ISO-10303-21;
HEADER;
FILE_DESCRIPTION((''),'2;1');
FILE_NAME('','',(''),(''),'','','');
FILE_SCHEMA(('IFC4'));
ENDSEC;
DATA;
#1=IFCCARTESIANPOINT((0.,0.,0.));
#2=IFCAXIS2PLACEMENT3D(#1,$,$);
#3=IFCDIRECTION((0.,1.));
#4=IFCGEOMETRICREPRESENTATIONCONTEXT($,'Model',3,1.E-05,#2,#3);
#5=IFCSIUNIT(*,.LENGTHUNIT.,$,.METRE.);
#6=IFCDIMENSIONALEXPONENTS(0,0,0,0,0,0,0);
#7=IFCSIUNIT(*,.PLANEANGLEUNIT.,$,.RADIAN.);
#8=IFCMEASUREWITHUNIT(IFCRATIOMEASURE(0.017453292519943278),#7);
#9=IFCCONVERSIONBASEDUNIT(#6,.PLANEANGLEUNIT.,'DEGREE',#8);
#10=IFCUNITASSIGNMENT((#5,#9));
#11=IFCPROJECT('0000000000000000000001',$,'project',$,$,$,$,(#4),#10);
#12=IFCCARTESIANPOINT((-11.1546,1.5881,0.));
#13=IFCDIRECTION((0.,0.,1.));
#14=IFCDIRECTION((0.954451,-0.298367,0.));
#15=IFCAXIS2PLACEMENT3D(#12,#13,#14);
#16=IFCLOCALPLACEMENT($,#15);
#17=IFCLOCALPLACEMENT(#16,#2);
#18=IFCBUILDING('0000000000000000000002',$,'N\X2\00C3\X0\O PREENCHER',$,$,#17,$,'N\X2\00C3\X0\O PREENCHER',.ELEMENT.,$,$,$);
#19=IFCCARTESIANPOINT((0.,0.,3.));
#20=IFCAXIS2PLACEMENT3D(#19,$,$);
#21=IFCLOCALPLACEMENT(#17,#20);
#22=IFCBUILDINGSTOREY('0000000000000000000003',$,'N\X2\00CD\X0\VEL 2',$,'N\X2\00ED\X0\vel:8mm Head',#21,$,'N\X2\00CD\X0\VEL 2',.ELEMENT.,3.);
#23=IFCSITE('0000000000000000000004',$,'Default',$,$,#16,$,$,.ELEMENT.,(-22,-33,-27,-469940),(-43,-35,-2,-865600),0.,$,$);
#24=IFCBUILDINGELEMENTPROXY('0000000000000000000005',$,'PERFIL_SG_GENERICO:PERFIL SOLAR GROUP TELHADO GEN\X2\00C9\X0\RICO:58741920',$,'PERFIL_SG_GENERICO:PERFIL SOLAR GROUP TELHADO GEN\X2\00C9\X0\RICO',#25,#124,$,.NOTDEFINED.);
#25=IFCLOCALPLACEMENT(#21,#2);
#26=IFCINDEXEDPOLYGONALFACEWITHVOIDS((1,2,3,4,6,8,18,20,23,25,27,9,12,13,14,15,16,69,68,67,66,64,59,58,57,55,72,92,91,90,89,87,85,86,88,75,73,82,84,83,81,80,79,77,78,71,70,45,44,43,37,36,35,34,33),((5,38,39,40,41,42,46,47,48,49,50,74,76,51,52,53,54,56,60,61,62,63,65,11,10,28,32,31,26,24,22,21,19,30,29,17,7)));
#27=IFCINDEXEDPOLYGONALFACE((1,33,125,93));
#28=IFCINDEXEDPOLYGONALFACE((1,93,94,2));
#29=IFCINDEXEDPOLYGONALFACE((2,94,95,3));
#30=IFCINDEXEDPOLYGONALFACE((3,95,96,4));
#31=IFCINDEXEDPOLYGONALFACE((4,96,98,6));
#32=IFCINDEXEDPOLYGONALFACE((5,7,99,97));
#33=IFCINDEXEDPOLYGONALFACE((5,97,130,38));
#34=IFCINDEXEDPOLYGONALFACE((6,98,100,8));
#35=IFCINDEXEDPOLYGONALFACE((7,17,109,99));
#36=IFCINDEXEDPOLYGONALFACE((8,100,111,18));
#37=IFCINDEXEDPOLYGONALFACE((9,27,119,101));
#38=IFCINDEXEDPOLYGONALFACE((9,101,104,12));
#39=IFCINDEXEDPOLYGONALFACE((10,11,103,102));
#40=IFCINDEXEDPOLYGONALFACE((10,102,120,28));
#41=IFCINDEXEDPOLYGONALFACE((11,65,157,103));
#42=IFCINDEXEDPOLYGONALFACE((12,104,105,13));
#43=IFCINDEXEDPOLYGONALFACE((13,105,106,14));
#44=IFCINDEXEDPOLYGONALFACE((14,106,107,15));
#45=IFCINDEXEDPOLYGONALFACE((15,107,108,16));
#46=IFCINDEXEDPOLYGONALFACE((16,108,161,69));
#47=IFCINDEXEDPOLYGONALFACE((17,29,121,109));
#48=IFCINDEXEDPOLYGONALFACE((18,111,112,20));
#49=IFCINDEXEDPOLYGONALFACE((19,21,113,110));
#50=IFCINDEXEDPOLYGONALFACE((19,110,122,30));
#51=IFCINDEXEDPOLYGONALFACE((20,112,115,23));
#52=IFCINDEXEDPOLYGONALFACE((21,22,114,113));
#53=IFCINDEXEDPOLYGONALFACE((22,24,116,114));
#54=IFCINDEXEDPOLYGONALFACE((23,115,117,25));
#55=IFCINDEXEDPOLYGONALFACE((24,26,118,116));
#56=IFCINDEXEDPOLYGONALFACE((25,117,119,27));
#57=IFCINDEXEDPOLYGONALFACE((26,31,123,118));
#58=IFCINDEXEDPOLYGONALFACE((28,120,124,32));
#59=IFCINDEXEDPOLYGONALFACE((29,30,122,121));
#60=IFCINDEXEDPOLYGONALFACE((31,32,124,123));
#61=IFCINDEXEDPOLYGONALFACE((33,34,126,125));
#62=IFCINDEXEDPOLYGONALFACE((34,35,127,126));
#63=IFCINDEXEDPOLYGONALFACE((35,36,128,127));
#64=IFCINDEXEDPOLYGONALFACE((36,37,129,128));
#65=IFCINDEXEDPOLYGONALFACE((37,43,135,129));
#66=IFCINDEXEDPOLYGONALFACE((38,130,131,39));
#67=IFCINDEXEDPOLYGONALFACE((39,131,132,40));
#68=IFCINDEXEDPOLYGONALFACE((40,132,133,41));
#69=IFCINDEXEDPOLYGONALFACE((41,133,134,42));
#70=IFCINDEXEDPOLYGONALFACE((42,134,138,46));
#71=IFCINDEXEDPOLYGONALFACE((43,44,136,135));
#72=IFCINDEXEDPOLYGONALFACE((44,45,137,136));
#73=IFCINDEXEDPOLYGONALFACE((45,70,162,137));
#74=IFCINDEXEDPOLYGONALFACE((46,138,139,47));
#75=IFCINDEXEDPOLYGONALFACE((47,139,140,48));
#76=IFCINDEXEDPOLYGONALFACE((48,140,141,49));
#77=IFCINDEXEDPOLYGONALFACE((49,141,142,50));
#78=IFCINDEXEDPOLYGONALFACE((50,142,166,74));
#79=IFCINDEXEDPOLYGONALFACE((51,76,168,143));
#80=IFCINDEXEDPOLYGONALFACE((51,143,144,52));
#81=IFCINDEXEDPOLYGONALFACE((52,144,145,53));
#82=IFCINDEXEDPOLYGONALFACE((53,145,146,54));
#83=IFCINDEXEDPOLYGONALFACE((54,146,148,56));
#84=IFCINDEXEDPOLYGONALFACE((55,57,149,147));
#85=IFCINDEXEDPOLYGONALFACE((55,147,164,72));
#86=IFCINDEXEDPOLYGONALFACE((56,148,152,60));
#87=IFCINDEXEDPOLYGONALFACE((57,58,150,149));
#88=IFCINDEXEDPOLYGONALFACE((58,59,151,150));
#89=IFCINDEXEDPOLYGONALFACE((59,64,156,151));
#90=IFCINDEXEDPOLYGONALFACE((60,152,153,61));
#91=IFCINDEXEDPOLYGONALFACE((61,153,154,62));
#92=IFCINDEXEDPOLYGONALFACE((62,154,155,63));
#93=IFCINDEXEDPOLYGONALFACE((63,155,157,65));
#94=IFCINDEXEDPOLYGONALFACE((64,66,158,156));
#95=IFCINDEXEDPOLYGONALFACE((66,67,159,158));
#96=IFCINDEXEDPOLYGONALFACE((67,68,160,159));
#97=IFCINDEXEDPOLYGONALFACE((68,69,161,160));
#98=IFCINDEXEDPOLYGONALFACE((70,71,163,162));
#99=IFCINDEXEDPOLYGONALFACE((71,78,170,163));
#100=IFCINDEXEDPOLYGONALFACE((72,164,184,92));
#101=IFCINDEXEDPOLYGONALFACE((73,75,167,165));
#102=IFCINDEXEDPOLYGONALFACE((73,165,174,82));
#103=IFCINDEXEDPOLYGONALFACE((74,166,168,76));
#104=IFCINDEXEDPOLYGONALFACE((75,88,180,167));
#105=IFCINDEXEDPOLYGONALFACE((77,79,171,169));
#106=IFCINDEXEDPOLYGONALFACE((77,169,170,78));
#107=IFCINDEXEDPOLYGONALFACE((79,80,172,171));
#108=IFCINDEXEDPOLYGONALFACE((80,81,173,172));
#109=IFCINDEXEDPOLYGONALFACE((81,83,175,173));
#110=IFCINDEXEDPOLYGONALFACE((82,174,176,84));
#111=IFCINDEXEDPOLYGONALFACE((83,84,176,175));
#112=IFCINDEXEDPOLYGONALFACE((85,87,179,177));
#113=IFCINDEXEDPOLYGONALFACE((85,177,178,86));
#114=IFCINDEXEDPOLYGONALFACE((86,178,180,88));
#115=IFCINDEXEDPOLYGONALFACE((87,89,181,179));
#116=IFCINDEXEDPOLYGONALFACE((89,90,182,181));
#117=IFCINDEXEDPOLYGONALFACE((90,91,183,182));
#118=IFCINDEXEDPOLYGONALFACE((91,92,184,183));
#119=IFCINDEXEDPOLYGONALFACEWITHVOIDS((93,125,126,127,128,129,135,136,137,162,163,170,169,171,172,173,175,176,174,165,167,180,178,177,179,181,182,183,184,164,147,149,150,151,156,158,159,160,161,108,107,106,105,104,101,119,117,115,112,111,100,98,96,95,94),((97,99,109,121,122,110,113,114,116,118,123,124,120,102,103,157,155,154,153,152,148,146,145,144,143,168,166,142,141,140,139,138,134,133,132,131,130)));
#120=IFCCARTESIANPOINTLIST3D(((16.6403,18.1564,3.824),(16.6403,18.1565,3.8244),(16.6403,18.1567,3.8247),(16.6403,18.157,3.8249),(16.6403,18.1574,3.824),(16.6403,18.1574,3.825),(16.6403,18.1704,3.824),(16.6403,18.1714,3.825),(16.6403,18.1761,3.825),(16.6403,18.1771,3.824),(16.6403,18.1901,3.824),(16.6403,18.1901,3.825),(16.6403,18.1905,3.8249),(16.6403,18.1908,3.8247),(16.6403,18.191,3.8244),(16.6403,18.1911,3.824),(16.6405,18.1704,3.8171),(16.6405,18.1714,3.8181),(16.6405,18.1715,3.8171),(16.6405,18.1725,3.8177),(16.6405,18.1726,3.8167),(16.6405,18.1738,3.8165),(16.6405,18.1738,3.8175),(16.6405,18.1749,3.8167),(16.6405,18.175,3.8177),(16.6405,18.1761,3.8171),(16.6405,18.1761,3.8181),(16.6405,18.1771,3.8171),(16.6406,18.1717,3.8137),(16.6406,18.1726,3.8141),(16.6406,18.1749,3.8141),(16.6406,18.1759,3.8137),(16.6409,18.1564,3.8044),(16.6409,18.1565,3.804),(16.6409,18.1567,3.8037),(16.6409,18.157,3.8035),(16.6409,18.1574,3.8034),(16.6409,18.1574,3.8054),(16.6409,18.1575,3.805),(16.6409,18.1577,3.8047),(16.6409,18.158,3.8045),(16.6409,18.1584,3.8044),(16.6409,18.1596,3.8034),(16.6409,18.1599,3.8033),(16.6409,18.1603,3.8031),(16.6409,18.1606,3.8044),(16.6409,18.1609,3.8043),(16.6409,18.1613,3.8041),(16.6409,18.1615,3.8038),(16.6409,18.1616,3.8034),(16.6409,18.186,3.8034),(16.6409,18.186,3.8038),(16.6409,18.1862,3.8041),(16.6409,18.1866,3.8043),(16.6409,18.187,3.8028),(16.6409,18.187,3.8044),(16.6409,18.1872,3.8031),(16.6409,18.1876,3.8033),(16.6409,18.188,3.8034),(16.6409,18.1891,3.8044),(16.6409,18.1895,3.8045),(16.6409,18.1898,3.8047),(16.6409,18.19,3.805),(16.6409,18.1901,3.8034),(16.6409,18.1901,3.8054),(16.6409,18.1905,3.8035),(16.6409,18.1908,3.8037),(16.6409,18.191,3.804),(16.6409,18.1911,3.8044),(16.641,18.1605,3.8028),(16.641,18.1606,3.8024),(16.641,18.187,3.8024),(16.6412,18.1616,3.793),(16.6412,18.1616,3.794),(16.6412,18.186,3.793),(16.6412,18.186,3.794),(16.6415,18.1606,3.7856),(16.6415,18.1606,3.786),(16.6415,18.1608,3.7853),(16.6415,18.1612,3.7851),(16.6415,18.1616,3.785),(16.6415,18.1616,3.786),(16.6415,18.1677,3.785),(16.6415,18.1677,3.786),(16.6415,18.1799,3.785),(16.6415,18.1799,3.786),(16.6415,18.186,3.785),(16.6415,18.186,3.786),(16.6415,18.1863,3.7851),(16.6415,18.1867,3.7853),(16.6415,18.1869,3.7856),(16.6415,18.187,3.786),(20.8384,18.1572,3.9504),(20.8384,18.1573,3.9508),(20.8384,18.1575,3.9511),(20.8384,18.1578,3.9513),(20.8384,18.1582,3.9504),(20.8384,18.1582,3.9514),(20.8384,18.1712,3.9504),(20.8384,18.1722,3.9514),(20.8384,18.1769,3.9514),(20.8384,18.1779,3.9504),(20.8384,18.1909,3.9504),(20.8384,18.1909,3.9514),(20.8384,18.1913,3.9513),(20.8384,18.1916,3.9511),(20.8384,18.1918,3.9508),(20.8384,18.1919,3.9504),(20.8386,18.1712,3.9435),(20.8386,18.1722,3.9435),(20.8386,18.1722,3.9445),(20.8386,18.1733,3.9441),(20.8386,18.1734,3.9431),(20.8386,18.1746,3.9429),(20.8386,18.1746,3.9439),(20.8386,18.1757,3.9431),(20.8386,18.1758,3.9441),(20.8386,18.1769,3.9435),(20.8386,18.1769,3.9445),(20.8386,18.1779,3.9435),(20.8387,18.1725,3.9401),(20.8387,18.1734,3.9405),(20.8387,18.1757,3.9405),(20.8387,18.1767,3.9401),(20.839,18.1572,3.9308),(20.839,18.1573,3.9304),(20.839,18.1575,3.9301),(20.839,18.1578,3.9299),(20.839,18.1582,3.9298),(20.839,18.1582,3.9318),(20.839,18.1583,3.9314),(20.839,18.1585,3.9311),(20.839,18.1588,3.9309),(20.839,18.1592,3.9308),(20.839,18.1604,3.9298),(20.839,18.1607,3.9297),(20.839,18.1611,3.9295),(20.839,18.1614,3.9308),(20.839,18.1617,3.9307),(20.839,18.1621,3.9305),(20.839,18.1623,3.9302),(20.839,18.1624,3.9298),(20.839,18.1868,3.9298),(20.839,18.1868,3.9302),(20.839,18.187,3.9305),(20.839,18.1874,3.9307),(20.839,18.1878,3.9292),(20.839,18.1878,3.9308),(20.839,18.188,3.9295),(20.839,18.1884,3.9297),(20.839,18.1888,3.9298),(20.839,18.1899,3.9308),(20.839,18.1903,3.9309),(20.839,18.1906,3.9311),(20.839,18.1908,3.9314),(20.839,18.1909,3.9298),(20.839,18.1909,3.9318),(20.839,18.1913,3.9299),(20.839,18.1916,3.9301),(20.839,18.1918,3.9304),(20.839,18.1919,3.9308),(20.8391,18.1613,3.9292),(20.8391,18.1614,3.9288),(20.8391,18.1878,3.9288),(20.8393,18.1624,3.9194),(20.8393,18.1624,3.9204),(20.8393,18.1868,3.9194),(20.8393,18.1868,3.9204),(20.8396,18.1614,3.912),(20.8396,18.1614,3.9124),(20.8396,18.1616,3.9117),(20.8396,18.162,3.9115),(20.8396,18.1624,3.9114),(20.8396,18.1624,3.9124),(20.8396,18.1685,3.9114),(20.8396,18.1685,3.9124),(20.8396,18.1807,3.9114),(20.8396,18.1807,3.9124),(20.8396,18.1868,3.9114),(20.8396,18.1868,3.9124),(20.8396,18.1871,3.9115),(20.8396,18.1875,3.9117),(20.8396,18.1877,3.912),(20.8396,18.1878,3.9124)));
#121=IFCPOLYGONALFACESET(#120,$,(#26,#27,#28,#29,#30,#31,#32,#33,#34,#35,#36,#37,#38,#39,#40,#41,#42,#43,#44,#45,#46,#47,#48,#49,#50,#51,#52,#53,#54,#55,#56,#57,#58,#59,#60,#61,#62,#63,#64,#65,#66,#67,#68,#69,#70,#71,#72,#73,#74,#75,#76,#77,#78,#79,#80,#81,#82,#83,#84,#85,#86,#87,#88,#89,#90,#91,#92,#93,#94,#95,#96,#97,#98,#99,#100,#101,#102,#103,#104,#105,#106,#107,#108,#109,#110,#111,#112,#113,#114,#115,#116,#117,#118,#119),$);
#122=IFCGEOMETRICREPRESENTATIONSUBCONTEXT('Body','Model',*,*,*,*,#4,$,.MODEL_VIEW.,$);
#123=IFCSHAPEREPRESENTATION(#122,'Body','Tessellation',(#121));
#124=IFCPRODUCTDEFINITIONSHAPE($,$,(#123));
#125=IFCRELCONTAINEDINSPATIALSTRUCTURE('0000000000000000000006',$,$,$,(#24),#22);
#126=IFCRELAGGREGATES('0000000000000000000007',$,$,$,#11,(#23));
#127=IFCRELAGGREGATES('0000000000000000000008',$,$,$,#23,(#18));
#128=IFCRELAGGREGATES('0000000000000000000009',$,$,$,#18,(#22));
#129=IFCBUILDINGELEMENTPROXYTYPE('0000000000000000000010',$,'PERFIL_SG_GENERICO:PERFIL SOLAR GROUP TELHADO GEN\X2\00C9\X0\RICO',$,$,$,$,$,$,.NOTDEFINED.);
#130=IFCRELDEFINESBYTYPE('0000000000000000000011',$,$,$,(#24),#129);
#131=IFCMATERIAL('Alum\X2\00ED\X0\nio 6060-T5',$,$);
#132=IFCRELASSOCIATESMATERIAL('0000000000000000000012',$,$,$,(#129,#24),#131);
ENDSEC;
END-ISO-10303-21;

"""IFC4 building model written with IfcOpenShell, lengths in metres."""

from ifc_helpers import new_model, entity, si_unit, converted_unit, direction, frame, origin, place, context, subcontext, project, spatial, line, arc, indexed_curve, outline, extrude, source, transform, mapped, material, type_object, type_shapes, element, save


model = new_model("IFC4")

# Units and contexts
model_context = context("Model", 3, precision=1e-05, world=origin(), true_north=direction((0.0, 1.0)))
body_context = subcontext(model_context, "Body", "Model", "MODEL_VIEW")
ifc_project = project(units=[si_unit("LENGTHUNIT", "METRE"), converted_unit("PLANEANGLEUNIT", "DEGREE", entity("IfcRatioMeasure", 0.017453292519943278), si_unit("PLANEANGLEUNIT", "RADIAN"), dimensions=[0, 0, 0, 0, 0, 0, 0])], contexts=[model_context])

# Site, building, storey
site_placement = place(None, frame((-11.1546, 1.5881, 0.0), z_axis=(0.0, 0.0, 1.0), x_axis=(0.954451, -0.298367, 0.0)))
site = spatial("IfcSite", under=ifc_project, at=site_placement, Name="Default", CompositionType="ELEMENT", RefLatitude=(-22, -33, -27, -469940), RefLongitude=(-43, -35, -2, -865600), RefElevation=0.0)
building_placement = place(site_placement, origin())
building = spatial("IfcBuilding", under=site, at=building_placement, Name="NÃO PREENCHER", LongName="NÃO PREENCHER", CompositionType="ELEMENT")
storey_placement = place(building_placement, frame((0.0, 0.0, 3.0)))
storey = spatial("IfcBuildingStorey", under=building, at=storey_placement, Name="NÍVEL 2", ObjectType="Nível:8mm Head", LongName="NÍVEL 2", CompositionType="ELEMENT", Elevation=3.0)

# Building element proxy
ifc_material_1 = material(Name="Alumínio 6060-T5")
building_element_proxy_type_1 = type_object("IfcBuildingElementProxyType", Name="PERFIL_SG_GENERICO:PERFIL SOLAR GROUP TELHADO GENÉRICO", PredefinedType="NOTDEFINED", material=ifc_material_1)
shared_shape_1 = source(origin(), body_context, "Body", "SweptSolid", [
    extrude(outline(indexed_curve([(-0.0122, -0.0169), (-0.0061, -0.0169), (-0.0061, -0.0159), (-0.0122, -0.0159), (-0.0122, -0.0089), (0.0122, -0.0089), (0.0122, -0.0159), (0.0061, -0.0159), (0.0061, -0.0169), (0.0122, -0.0169), (0.0129, -0.0166), (0.0132, -0.0159), (0.0132, 0.0005), (0.0135, 0.0012), (0.0142, 0.0015), (0.0164, 0.0015), (0.0171, 0.0018), (0.0174, 0.0025), (0.0174, 0.0221), (0.0171, 0.0228), (0.0164, 0.0231), (0.0024, 0.0231), (0.0024, 0.0162), (0.0, 0.0156), (-0.0024, 0.0162), (-0.0024, 0.0231), (-0.0164, 0.0231), (-0.0171, 0.0228), (-0.0174, 0.0221), (-0.0174, 0.0025), (-0.0171, 0.0018), (-0.0164, 0.0015), (-0.0142, 0.0015), (-0.0135, 0.0012), (-0.0132, 0.0005), (-0.0132, -0.0159), (-0.0129, -0.0166)], segments=[line(1, 2, 3, 4, 5, 6, 7, 8, 9, 10), arc(10, 11, 12), line(12, 13), arc(13, 14, 15), line(15, 16), arc(16, 17, 18), line(18, 19), arc(19, 20, 21), line(21, 22, 23), arc(23, 24, 25), line(25, 26, 27), arc(27, 28, 29), line(29, 30), arc(30, 31, 32), line(32, 33), arc(33, 34, 35), line(35, 36), arc(36, 37, 1)], self_intersect=False), holes=[indexed_curve([(-0.0122, -0.0079), (-0.0122, 0.0015), (-0.0125, 0.0022), (-0.0132, 0.0025), (-0.0154, 0.0025), (-0.0161, 0.0028), (-0.0164, 0.0035), (-0.0164, 0.0221), (-0.0034, 0.0221), (-0.0034, 0.0152), (-0.0021, 0.0118), (-0.0012, 0.0122), (-0.0023, 0.0151), (0.0, 0.0146), (0.0023, 0.0151), (0.0012, 0.0122), (0.0021, 0.0118), (0.0034, 0.0152), (0.0034, 0.0221), (0.0164, 0.0221), (0.0164, 0.0035), (0.0161, 0.0028), (0.0154, 0.0025), (0.0132, 0.0025), (0.0125, 0.0022), (0.0122, 0.0015), (0.0122, -0.0079)], segments=[line(1, 2), arc(2, 3, 4), line(4, 5), arc(5, 6, 7), line(7, 8, 9, 10, 11, 12, 13), arc(13, 14, 15), line(15, 16, 17, 18, 19, 20, 21), arc(21, 22, 23), line(23, 24), arc(24, 25, 26), line(26, 27, 1)], self_intersect=False)]), frame((0.0, 0.0, 0.0169), z_axis=(1.0, 0.0, 0.0), x_axis=(0.0, 1.0, 0.0)), (0.0, 0.0, 1.0), 4.2),
])
type_shapes(building_element_proxy_type_1, [shared_shape_1])
for number, where, z_axis, x_axis, name in (
    (1, (16.6415, 18.1738, 3.785), (-0.030095, 0.0, 0.999547), (0.999547, 0.00019, 0.030095), "PERFIL_SG_GENERICO:PERFIL SOLAR GROUP TELHADO GENÉRICO:58741920"),
):
    element("IfcBuildingElementProxy", number, at=place(storey_placement, frame(where, z_axis=z_axis, x_axis=x_axis)), inside=storey, type_object=building_element_proxy_type_1, material=ifc_material_1, Name=name, ObjectType="PERFIL_SG_GENERICO:PERFIL SOLAR GROUP TELHADO GENÉRICO", PredefinedType="NOTDEFINED", context=body_context, shape_type="MappedRepresentation", body=[
        mapped(shared_shape_1, transform((0.0, 0.0, 0.0), scale=1.0)),
    ])

save(model, "model.ifc")
